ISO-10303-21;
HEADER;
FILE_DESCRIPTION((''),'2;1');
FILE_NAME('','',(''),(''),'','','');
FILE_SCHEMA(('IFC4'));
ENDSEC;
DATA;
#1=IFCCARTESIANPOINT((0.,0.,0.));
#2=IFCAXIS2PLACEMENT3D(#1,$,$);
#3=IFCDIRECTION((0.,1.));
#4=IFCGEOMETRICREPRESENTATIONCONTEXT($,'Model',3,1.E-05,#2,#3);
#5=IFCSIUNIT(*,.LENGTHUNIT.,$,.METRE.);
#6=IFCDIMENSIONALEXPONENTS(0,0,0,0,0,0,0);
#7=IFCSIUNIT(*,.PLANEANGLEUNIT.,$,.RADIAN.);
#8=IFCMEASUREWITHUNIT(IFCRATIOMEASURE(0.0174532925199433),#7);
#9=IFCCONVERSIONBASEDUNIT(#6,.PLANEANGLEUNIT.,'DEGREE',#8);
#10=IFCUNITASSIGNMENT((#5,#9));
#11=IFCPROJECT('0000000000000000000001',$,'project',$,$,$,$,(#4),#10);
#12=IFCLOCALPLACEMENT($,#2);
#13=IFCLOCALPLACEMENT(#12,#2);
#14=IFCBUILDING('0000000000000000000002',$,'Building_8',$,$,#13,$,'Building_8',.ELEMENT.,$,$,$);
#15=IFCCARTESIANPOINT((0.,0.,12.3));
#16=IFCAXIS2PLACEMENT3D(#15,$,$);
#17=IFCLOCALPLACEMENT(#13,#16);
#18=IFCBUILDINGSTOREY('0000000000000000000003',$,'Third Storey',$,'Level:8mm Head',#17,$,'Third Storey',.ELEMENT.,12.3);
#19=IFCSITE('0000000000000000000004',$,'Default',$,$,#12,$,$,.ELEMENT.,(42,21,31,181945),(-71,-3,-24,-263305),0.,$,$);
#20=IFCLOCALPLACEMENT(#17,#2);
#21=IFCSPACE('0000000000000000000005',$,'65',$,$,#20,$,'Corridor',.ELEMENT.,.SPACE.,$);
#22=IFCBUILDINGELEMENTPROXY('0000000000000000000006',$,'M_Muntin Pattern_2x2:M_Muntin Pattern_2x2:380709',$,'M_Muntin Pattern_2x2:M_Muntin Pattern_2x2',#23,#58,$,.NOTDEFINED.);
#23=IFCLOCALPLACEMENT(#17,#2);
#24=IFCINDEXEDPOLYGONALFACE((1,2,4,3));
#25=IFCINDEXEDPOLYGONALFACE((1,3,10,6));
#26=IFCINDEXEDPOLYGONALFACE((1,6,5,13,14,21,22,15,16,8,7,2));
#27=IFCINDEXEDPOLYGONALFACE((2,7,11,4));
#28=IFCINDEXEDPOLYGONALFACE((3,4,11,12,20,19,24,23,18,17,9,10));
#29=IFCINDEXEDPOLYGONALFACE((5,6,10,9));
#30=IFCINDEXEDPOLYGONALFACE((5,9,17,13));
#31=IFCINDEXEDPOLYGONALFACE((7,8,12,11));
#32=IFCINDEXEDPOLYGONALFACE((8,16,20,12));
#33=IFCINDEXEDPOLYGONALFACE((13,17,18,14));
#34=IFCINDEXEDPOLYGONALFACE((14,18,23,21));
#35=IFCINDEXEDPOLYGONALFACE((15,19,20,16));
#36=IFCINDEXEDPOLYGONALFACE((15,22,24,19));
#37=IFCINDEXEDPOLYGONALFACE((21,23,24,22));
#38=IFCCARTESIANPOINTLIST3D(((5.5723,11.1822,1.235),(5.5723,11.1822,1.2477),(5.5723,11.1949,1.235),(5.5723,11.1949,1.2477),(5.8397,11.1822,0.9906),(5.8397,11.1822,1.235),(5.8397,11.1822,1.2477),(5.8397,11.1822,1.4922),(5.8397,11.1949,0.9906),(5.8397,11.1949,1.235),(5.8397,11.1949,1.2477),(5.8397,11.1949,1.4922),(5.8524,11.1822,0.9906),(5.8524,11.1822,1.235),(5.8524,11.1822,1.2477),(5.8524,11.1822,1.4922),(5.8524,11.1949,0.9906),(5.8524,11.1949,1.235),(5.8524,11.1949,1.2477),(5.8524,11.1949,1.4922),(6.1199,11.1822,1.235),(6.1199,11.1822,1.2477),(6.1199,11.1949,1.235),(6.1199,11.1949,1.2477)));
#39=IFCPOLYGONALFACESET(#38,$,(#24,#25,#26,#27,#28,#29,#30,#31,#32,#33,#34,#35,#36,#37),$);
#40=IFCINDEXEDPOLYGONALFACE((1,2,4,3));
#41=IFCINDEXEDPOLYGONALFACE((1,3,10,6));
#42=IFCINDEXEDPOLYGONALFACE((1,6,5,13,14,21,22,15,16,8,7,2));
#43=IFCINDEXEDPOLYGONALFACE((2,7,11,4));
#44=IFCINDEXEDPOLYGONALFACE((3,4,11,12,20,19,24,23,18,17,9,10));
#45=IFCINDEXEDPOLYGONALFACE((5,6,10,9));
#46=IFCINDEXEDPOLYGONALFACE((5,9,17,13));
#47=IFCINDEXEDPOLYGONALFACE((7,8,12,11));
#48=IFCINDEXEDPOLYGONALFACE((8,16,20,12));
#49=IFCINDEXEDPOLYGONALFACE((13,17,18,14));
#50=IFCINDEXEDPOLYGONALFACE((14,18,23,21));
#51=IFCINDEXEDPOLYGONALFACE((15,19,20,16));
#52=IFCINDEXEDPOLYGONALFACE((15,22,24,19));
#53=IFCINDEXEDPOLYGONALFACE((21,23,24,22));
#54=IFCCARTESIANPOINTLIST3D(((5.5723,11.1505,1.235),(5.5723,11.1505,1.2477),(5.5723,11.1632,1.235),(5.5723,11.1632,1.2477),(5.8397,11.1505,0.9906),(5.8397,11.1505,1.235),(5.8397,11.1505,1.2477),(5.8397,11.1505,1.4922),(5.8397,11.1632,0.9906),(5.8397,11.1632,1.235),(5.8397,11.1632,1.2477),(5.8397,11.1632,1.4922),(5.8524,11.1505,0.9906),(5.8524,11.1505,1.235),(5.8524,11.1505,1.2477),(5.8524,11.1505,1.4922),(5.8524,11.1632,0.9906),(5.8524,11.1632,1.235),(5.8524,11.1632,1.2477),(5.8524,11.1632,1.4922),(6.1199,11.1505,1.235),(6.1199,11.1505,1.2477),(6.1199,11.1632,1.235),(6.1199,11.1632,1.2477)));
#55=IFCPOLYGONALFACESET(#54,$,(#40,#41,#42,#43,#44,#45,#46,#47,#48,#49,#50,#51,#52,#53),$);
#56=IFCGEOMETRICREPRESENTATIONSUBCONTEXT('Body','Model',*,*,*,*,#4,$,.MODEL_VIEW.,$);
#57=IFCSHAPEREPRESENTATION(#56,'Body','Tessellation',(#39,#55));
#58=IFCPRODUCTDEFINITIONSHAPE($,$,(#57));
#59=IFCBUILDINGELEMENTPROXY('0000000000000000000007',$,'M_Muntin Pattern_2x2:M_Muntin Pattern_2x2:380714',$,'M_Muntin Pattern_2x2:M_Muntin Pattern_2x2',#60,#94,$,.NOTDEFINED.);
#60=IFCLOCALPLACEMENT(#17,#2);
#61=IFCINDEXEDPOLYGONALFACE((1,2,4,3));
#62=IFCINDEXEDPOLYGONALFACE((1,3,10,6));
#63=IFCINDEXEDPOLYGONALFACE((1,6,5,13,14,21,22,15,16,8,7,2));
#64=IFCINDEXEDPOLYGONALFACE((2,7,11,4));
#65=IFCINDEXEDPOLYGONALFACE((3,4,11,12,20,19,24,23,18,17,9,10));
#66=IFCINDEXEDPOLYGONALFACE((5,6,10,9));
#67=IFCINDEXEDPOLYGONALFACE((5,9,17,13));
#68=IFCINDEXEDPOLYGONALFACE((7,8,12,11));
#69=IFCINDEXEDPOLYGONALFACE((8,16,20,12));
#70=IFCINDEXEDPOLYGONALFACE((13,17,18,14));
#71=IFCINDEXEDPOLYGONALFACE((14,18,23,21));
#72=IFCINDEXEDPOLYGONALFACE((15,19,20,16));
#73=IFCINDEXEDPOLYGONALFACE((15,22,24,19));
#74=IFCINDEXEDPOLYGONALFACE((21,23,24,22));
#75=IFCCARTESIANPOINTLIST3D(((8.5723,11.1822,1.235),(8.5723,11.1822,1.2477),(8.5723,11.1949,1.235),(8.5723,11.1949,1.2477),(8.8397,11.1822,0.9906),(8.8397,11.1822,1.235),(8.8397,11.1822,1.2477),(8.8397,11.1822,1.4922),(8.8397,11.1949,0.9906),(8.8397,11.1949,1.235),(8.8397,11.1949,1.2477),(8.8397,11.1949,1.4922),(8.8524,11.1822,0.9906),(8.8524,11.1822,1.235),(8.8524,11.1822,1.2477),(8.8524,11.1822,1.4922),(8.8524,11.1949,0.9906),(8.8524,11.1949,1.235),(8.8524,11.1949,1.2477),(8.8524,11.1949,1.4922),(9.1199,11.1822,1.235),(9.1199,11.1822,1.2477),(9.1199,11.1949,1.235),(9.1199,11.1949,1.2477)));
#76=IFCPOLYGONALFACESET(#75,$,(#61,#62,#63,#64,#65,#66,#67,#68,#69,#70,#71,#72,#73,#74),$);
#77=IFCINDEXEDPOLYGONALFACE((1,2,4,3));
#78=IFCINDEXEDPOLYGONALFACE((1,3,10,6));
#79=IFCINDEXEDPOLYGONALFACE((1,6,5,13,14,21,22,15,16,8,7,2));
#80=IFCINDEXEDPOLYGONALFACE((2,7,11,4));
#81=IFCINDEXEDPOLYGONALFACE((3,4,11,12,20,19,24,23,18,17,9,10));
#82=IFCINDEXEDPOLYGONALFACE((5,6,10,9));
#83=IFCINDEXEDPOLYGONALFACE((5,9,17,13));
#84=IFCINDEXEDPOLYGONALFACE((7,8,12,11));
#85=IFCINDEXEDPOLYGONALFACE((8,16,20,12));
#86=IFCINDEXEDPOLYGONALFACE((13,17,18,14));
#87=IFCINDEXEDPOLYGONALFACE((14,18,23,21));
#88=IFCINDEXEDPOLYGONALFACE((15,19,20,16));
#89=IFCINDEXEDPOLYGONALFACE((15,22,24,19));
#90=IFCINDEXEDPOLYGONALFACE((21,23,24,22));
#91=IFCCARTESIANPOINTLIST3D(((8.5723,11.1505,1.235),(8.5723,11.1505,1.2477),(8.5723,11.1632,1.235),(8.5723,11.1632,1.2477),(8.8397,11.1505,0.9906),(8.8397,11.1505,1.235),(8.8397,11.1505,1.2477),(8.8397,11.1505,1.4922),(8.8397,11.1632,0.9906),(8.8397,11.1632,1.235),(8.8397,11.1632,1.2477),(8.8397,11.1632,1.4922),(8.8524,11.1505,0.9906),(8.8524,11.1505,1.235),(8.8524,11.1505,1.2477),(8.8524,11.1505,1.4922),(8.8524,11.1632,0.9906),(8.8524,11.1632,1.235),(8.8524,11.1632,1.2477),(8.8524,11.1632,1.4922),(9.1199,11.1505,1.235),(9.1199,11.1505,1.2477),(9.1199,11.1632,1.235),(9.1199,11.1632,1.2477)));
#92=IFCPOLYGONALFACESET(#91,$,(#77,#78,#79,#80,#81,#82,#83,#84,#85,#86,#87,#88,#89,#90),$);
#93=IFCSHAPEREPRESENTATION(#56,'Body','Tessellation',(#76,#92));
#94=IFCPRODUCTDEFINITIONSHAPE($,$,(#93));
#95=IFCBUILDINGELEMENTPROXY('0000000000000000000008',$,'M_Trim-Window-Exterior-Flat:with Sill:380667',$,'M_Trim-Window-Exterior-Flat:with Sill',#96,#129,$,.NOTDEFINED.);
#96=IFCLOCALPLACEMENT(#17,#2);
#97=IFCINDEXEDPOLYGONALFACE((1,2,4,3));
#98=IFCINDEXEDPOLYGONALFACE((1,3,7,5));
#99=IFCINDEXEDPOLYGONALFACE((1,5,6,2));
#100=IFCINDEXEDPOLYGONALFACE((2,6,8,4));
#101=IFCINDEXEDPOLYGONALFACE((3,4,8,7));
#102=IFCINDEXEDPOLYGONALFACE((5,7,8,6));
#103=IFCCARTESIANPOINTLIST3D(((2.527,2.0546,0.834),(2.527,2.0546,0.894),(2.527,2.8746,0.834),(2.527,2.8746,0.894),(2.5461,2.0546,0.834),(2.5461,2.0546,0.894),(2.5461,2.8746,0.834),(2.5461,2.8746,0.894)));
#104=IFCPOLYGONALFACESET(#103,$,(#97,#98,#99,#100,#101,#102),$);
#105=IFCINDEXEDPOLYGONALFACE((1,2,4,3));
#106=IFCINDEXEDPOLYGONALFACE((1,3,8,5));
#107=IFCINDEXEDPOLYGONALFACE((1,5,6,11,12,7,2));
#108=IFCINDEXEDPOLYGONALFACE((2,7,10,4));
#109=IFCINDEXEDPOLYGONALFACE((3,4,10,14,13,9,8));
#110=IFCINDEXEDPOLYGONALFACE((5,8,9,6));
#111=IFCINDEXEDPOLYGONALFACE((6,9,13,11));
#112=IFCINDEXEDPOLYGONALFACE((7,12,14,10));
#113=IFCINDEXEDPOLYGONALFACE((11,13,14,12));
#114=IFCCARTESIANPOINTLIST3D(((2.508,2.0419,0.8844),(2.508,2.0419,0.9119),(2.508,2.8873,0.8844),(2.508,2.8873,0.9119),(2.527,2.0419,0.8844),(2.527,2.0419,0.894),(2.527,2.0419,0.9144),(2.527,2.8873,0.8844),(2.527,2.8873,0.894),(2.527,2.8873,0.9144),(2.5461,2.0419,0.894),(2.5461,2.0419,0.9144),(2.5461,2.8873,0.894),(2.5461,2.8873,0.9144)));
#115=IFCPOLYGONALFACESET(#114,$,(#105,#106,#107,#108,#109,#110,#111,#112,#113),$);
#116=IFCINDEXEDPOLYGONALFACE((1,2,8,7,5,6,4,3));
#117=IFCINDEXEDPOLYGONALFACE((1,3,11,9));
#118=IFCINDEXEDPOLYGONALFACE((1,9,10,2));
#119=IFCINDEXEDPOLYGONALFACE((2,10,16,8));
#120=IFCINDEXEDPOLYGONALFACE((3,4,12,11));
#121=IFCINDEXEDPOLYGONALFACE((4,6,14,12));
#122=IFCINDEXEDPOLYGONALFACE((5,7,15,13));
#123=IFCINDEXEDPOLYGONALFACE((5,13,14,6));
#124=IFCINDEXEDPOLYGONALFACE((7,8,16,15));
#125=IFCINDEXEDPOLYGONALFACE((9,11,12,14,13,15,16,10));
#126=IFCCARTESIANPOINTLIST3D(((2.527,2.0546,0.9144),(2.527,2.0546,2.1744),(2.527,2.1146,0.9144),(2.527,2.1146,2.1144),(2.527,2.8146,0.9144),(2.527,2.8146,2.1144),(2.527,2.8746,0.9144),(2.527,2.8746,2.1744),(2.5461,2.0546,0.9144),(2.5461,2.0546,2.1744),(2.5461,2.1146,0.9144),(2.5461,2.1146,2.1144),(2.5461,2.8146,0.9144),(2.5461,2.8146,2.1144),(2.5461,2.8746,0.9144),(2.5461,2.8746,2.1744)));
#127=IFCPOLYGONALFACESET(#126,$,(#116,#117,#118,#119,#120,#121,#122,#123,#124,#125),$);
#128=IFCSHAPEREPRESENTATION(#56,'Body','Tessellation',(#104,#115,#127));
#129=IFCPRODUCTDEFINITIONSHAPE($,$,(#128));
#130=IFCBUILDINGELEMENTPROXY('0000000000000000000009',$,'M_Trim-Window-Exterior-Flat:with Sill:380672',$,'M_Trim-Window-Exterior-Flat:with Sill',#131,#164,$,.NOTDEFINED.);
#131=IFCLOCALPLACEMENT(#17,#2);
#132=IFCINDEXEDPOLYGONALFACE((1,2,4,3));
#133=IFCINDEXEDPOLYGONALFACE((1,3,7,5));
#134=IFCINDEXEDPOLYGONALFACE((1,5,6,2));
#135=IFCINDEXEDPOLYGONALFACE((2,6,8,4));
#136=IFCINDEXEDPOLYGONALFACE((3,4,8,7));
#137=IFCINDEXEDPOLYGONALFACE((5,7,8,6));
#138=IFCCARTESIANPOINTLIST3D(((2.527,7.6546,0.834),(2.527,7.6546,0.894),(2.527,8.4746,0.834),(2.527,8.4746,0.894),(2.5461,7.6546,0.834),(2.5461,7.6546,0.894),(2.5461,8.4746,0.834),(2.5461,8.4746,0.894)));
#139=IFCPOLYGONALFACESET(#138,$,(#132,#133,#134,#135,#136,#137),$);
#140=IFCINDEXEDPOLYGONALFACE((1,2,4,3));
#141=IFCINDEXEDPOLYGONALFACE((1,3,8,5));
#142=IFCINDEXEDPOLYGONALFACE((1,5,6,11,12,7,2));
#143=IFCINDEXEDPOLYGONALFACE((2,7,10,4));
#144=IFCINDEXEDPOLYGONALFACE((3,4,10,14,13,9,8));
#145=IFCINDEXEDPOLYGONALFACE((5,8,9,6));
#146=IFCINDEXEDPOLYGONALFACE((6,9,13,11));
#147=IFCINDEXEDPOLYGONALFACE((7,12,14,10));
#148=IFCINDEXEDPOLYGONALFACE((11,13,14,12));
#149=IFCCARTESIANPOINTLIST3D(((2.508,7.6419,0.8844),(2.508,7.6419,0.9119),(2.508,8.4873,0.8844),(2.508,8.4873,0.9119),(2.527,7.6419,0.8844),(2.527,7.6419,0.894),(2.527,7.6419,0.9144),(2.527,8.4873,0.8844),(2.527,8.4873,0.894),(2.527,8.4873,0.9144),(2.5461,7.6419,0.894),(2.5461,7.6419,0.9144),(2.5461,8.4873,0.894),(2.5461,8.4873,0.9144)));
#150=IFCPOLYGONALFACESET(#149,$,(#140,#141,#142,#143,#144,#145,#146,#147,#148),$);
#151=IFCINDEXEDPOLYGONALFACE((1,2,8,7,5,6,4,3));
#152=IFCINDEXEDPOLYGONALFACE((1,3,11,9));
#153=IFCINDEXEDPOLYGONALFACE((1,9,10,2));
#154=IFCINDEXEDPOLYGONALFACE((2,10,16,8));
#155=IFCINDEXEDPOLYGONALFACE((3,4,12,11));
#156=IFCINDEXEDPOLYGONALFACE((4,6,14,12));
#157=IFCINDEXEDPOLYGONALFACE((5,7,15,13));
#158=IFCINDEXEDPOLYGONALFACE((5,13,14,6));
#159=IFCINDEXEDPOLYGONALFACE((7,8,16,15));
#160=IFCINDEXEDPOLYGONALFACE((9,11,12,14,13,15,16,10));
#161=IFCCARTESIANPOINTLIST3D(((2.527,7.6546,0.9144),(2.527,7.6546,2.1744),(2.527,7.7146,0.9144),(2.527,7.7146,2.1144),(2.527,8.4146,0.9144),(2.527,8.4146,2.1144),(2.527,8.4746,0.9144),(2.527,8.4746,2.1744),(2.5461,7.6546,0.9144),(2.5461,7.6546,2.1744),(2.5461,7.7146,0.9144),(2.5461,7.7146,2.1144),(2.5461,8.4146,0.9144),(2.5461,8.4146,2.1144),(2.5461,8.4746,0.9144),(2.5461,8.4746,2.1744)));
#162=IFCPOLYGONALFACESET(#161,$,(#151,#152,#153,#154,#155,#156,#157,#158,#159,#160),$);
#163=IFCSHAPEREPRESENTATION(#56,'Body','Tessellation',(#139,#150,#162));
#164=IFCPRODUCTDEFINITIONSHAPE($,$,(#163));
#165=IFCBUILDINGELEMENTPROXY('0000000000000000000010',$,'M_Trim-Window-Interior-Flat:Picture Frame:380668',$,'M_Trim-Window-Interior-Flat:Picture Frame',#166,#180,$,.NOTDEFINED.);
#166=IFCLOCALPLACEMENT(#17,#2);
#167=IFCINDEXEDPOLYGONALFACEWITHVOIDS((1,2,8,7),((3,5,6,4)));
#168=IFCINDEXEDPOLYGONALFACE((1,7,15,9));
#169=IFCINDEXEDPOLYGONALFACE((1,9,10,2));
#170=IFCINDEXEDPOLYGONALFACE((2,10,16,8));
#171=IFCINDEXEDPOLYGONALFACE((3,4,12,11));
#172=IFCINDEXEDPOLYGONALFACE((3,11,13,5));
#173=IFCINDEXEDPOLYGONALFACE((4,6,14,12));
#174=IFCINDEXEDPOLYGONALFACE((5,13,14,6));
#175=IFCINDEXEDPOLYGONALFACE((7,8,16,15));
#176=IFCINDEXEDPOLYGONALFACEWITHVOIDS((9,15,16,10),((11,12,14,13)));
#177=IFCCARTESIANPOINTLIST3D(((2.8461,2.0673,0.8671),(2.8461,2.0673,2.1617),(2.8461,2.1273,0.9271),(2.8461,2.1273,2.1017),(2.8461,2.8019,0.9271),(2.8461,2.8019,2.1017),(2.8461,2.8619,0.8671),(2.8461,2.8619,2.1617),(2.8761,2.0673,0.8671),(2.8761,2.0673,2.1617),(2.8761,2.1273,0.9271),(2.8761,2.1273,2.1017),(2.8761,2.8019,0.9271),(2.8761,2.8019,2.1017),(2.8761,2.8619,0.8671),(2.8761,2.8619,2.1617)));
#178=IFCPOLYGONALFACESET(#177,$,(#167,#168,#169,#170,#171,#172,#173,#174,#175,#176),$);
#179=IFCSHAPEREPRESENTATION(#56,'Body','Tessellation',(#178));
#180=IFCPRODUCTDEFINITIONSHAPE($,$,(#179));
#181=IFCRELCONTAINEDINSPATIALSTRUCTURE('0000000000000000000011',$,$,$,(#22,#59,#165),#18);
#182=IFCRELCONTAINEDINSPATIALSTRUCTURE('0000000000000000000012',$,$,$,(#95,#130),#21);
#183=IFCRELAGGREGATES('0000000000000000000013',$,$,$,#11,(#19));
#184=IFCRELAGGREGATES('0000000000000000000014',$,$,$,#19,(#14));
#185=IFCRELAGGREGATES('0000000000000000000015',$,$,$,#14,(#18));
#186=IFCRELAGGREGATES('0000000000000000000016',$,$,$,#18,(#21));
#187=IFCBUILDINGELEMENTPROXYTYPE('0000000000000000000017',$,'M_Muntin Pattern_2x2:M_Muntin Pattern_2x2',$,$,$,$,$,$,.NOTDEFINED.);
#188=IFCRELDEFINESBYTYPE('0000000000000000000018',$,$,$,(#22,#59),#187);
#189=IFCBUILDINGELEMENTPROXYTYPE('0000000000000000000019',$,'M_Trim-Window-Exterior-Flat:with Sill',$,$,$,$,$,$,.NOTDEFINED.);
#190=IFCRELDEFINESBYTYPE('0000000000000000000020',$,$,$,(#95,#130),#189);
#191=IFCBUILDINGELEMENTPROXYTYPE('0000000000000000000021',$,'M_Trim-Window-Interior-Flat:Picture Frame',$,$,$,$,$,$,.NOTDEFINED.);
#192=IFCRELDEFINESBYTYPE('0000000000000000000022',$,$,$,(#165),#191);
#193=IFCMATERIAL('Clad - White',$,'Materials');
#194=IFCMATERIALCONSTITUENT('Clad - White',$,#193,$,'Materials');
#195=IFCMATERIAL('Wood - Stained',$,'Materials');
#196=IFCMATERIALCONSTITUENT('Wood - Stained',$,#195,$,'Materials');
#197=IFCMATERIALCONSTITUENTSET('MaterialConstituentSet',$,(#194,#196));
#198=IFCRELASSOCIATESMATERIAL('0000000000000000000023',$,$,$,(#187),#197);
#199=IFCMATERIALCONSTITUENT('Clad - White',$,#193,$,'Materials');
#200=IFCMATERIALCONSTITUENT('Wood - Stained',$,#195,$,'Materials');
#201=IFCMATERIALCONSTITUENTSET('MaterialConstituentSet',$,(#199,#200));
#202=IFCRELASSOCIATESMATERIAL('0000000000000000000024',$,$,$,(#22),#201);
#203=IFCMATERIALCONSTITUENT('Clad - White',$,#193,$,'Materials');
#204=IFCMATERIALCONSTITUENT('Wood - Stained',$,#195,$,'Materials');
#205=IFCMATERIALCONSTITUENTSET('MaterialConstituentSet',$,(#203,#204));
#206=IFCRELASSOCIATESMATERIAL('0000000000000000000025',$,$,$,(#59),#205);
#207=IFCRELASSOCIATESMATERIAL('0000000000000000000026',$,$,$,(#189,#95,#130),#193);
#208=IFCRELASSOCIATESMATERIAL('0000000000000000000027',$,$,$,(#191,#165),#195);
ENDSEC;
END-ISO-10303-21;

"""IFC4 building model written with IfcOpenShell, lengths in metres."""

from ifc_helpers import new_model, entity, si_unit, converted_unit, direction, frame, origin, place, context, subcontext, project, spatial, indexed_curve, outline, extrude, source, transform, mapped, material, constituent, constituent_set, type_object, type_shapes, element, save


model = new_model("IFC4")

# Units and contexts
model_context = context("Model", 3, precision=1e-05, world=origin(), true_north=direction((0.0, 1.0)))
body_context = subcontext(model_context, "Body", "Model", "MODEL_VIEW")
ifc_project = project(units=[si_unit("LENGTHUNIT", "METRE"), converted_unit("PLANEANGLEUNIT", "DEGREE", entity("IfcRatioMeasure", 0.0174532925199433), si_unit("PLANEANGLEUNIT", "RADIAN"), dimensions=[0, 0, 0, 0, 0, 0, 0])], contexts=[model_context])

# Site, building, storey
site_placement = place(None, origin())
site = spatial("IfcSite", under=ifc_project, at=site_placement, Name="Default", CompositionType="ELEMENT", RefLatitude=(42, 21, 31, 181945), RefLongitude=(-71, -3, -24, -263305), RefElevation=0.0)
building_placement = place(site_placement, origin())
building = spatial("IfcBuilding", under=site, at=building_placement, Name="Building_8", LongName="Building_8", CompositionType="ELEMENT")
storey_placement = place(building_placement, frame((0.0, 0.0, 12.3)))
storey = spatial("IfcBuildingStorey", under=building, at=storey_placement, Name="Third Storey", ObjectType="Level:8mm Head", LongName="Third Storey", CompositionType="ELEMENT", Elevation=12.3)

# Building element proxies
ifc_material_1 = material(Name="Clad - White", Category="Materials")
ifc_material_2 = material(Name="Wood - Stained", Category="Materials")
ifc_constituent_1 = constituent(ifc_material_1, Name="Clad - White", Category="Materials")
ifc_constituent_2 = constituent(ifc_material_2, Name="Wood - Stained", Category="Materials")
ifc_constituent_set_1 = constituent_set(constituents=[ifc_constituent_1, ifc_constituent_2], Name="MaterialConstituentSet")
building_element_proxy_type_1 = type_object("IfcBuildingElementProxyType", Name="M_Muntin Pattern_2x2:M_Muntin Pattern_2x2", PredefinedType="NOTDEFINED", material=ifc_constituent_set_1)
shared_shape_1 = source(origin(), body_context, "Body", "SweptSolid", [
    extrude(outline(indexed_curve([(0.0064, -0.0064), (0.2508, -0.0064), (0.2508, 0.0063), (0.0064, 0.0063), (0.0064, 0.2738), (-0.0063, 0.2738), (-0.0063, 0.0063), (-0.2508, 0.0063), (-0.2508, -0.0064), (-0.0063, -0.0064), (-0.0063, -0.2738), (0.0064, -0.2738), (0.0064, -0.0064)], self_intersect=False)), frame((0.0, 0.0095, 0.2508), z_axis=(0.0, 1.0, 0.0), x_axis=(0.0, 0.0, 1.0)), (0.0, 0.0, 1.0), 0.0127),
    extrude(outline(indexed_curve([(0.0064, -0.0064), (0.2508, -0.0064), (0.2508, 0.0063), (0.0064, 0.0063), (0.0064, 0.2738), (-0.0063, 0.2738), (-0.0063, 0.0063), (-0.2508, 0.0063), (-0.2508, -0.0064), (-0.0063, -0.0064), (-0.0063, -0.2738), (0.0064, -0.2738), (0.0064, -0.0064)], self_intersect=False)), frame((0.0, -0.0222, 0.2508), z_axis=(0.0, 1.0, 0.0), x_axis=(0.0, 0.0, 1.0)), (0.0, 0.0, 1.0), 0.0127),
])
type_shapes(building_element_proxy_type_1, [shared_shape_1])
ifc_constituent_3 = constituent(ifc_material_1, Name="Clad - White", Category="Materials")
ifc_constituent_4 = constituent(ifc_material_2, Name="Wood - Stained", Category="Materials")
ifc_constituent_set_2 = constituent_set(constituents=[ifc_constituent_3, ifc_constituent_4], Name="MaterialConstituentSet")
proxy_1_placement = place(storey_placement, frame((5.8461, 11.1727, 0.9906)))
element("IfcBuildingElementProxy", 1, at=proxy_1_placement, inside=storey, type_object=building_element_proxy_type_1, material=ifc_constituent_set_2, Name="M_Muntin Pattern_2x2:M_Muntin Pattern_2x2:380709", ObjectType="M_Muntin Pattern_2x2:M_Muntin Pattern_2x2", PredefinedType="NOTDEFINED", context=body_context, shape_type="MappedRepresentation", body=[
    mapped(shared_shape_1, transform((0.0, 0.0, 0.0), scale=1.0)),
])
ifc_constituent_5 = constituent(ifc_material_1, Name="Clad - White", Category="Materials")
ifc_constituent_6 = constituent(ifc_material_2, Name="Wood - Stained", Category="Materials")
ifc_constituent_set_3 = constituent_set(constituents=[ifc_constituent_5, ifc_constituent_6], Name="MaterialConstituentSet")
proxy_2_placement = place(storey_placement, frame((8.8461, 11.1727, 0.9906)))
element("IfcBuildingElementProxy", 2, at=proxy_2_placement, inside=storey, type_object=building_element_proxy_type_1, material=ifc_constituent_set_3, Name="M_Muntin Pattern_2x2:M_Muntin Pattern_2x2:380714", ObjectType="M_Muntin Pattern_2x2:M_Muntin Pattern_2x2", PredefinedType="NOTDEFINED", context=body_context, shape_type="MappedRepresentation", body=[
    mapped(shared_shape_1, transform((0.0, 0.0, 0.0), scale=1.0)),
])

# Shared definitions
space_placement = place(storey_placement, origin())
space = spatial("IfcSpace", under=storey, at=space_placement, Name="65", LongName="Corridor", CompositionType="ELEMENT", PredefinedType="SPACE")

# Building element proxies
building_element_proxy_type_2 = type_object("IfcBuildingElementProxyType", Name="M_Trim-Window-Exterior-Flat:with Sill", PredefinedType="NOTDEFINED", material=ifc_material_1)
shared_shape_2 = source(origin(), body_context, "Body", "SweptSolid", [
    extrude(outline(indexed_curve([(-0.41, -0.03), (0.41, -0.03), (0.41, 0.03), (-0.41, 0.03), (-0.41, -0.03)], self_intersect=False)), frame((0.0, -1.2504, 0.0), z_axis=(0.0, 0.0, 1.0), x_axis=(-1.0, 0.0, 0.0)), (0.0, 0.0, 1.0), 0.0191),
    extrude(outline(indexed_curve([(-0.019, -0.0152), (0.0, -0.0152), (0.0, -0.0057), (0.019, -0.0057), (0.019, 0.0148), (0.0, 0.0148), (-0.019, 0.0123), (-0.019, -0.0152)], self_intersect=False)), frame((-0.4227, -1.2148, 0.019), z_axis=(1.0, 0.0, 0.0), x_axis=(0.0, 0.0, -1.0)), (0.0, 0.0, 1.0), 0.8454),
    extrude(outline(indexed_curve([(-0.645, -0.41), (0.615, -0.41), (0.615, -0.35), (-0.585, -0.35), (-0.585, 0.35), (0.615, 0.35), (0.615, 0.41), (-0.645, 0.41), (-0.645, -0.41)], self_intersect=False)), frame((0.0, -0.585, 0.0), z_axis=(0.0, 0.0, 1.0), x_axis=(0.0, -1.0, 0.0)), (0.0, 0.0, 1.0), 0.0191),
])
type_shapes(building_element_proxy_type_2, [shared_shape_2])
for number, where, z_axis, x_axis, name in (
    (3, (2.5461, 2.4646, 2.1144), (-1.0, 0.0, 0.0), (0.0, -1.0, 0.0), "M_Trim-Window-Exterior-Flat:with Sill:380667"),
    (4, (2.5461, 8.0646, 2.1144), (-1.0, 0.0, 0.0), (0.0, -1.0, 0.0), "M_Trim-Window-Exterior-Flat:with Sill:380672"),
):
    element("IfcBuildingElementProxy", number, at=place(space_placement, frame(where, z_axis=z_axis, x_axis=x_axis)), inside=space, type_object=building_element_proxy_type_2, material=ifc_material_1, Name=name, ObjectType="M_Trim-Window-Exterior-Flat:with Sill", PredefinedType="NOTDEFINED", context=body_context, shape_type="MappedRepresentation", body=[
        mapped(shared_shape_2, transform((0.0, 0.0, 0.0), scale=1.0)),
    ])
building_element_proxy_type_3 = type_object("IfcBuildingElementProxyType", Name="M_Trim-Window-Interior-Flat:Picture Frame", PredefinedType="NOTDEFINED", material=ifc_material_2)
shared_shape_3 = source(origin(), body_context, "Body", "SweptSolid", [
    extrude(outline(indexed_curve([(-0.3973, -0.6473), (0.3973, -0.6473), (0.3973, 0.6473), (-0.3973, 0.6473), (-0.3973, -0.6473)], self_intersect=False), holes=[indexed_curve([(-0.3373, -0.5873), (-0.3373, 0.5873), (0.3373, 0.5873), (0.3373, -0.5873), (-0.3373, -0.5873)], self_intersect=False)]), frame((0.0, -0.6, 0.0), z_axis=(0.0, 0.0, 1.0), x_axis=(-1.0, 0.0, 0.0)), (0.0, 0.0, 1.0), 0.03),
])
type_shapes(building_element_proxy_type_3, [shared_shape_3])
for number, where, z_axis, x_axis, name in (
    (5, (2.8461, 2.4646, 2.1144), (1.0, 0.0, 0.0), (0.0, 1.0, 0.0), "M_Trim-Window-Interior-Flat:Picture Frame:380668"),
):
    element("IfcBuildingElementProxy", number, at=place(storey_placement, frame(where, z_axis=z_axis, x_axis=x_axis)), inside=storey, type_object=building_element_proxy_type_3, material=ifc_material_2, Name=name, ObjectType="M_Trim-Window-Interior-Flat:Picture Frame", PredefinedType="NOTDEFINED", context=body_context, shape_type="MappedRepresentation", body=[
        mapped(shared_shape_3, transform((0.0, 0.0, 0.0), scale=1.0)),
    ])

save(model, "model.ifc")
